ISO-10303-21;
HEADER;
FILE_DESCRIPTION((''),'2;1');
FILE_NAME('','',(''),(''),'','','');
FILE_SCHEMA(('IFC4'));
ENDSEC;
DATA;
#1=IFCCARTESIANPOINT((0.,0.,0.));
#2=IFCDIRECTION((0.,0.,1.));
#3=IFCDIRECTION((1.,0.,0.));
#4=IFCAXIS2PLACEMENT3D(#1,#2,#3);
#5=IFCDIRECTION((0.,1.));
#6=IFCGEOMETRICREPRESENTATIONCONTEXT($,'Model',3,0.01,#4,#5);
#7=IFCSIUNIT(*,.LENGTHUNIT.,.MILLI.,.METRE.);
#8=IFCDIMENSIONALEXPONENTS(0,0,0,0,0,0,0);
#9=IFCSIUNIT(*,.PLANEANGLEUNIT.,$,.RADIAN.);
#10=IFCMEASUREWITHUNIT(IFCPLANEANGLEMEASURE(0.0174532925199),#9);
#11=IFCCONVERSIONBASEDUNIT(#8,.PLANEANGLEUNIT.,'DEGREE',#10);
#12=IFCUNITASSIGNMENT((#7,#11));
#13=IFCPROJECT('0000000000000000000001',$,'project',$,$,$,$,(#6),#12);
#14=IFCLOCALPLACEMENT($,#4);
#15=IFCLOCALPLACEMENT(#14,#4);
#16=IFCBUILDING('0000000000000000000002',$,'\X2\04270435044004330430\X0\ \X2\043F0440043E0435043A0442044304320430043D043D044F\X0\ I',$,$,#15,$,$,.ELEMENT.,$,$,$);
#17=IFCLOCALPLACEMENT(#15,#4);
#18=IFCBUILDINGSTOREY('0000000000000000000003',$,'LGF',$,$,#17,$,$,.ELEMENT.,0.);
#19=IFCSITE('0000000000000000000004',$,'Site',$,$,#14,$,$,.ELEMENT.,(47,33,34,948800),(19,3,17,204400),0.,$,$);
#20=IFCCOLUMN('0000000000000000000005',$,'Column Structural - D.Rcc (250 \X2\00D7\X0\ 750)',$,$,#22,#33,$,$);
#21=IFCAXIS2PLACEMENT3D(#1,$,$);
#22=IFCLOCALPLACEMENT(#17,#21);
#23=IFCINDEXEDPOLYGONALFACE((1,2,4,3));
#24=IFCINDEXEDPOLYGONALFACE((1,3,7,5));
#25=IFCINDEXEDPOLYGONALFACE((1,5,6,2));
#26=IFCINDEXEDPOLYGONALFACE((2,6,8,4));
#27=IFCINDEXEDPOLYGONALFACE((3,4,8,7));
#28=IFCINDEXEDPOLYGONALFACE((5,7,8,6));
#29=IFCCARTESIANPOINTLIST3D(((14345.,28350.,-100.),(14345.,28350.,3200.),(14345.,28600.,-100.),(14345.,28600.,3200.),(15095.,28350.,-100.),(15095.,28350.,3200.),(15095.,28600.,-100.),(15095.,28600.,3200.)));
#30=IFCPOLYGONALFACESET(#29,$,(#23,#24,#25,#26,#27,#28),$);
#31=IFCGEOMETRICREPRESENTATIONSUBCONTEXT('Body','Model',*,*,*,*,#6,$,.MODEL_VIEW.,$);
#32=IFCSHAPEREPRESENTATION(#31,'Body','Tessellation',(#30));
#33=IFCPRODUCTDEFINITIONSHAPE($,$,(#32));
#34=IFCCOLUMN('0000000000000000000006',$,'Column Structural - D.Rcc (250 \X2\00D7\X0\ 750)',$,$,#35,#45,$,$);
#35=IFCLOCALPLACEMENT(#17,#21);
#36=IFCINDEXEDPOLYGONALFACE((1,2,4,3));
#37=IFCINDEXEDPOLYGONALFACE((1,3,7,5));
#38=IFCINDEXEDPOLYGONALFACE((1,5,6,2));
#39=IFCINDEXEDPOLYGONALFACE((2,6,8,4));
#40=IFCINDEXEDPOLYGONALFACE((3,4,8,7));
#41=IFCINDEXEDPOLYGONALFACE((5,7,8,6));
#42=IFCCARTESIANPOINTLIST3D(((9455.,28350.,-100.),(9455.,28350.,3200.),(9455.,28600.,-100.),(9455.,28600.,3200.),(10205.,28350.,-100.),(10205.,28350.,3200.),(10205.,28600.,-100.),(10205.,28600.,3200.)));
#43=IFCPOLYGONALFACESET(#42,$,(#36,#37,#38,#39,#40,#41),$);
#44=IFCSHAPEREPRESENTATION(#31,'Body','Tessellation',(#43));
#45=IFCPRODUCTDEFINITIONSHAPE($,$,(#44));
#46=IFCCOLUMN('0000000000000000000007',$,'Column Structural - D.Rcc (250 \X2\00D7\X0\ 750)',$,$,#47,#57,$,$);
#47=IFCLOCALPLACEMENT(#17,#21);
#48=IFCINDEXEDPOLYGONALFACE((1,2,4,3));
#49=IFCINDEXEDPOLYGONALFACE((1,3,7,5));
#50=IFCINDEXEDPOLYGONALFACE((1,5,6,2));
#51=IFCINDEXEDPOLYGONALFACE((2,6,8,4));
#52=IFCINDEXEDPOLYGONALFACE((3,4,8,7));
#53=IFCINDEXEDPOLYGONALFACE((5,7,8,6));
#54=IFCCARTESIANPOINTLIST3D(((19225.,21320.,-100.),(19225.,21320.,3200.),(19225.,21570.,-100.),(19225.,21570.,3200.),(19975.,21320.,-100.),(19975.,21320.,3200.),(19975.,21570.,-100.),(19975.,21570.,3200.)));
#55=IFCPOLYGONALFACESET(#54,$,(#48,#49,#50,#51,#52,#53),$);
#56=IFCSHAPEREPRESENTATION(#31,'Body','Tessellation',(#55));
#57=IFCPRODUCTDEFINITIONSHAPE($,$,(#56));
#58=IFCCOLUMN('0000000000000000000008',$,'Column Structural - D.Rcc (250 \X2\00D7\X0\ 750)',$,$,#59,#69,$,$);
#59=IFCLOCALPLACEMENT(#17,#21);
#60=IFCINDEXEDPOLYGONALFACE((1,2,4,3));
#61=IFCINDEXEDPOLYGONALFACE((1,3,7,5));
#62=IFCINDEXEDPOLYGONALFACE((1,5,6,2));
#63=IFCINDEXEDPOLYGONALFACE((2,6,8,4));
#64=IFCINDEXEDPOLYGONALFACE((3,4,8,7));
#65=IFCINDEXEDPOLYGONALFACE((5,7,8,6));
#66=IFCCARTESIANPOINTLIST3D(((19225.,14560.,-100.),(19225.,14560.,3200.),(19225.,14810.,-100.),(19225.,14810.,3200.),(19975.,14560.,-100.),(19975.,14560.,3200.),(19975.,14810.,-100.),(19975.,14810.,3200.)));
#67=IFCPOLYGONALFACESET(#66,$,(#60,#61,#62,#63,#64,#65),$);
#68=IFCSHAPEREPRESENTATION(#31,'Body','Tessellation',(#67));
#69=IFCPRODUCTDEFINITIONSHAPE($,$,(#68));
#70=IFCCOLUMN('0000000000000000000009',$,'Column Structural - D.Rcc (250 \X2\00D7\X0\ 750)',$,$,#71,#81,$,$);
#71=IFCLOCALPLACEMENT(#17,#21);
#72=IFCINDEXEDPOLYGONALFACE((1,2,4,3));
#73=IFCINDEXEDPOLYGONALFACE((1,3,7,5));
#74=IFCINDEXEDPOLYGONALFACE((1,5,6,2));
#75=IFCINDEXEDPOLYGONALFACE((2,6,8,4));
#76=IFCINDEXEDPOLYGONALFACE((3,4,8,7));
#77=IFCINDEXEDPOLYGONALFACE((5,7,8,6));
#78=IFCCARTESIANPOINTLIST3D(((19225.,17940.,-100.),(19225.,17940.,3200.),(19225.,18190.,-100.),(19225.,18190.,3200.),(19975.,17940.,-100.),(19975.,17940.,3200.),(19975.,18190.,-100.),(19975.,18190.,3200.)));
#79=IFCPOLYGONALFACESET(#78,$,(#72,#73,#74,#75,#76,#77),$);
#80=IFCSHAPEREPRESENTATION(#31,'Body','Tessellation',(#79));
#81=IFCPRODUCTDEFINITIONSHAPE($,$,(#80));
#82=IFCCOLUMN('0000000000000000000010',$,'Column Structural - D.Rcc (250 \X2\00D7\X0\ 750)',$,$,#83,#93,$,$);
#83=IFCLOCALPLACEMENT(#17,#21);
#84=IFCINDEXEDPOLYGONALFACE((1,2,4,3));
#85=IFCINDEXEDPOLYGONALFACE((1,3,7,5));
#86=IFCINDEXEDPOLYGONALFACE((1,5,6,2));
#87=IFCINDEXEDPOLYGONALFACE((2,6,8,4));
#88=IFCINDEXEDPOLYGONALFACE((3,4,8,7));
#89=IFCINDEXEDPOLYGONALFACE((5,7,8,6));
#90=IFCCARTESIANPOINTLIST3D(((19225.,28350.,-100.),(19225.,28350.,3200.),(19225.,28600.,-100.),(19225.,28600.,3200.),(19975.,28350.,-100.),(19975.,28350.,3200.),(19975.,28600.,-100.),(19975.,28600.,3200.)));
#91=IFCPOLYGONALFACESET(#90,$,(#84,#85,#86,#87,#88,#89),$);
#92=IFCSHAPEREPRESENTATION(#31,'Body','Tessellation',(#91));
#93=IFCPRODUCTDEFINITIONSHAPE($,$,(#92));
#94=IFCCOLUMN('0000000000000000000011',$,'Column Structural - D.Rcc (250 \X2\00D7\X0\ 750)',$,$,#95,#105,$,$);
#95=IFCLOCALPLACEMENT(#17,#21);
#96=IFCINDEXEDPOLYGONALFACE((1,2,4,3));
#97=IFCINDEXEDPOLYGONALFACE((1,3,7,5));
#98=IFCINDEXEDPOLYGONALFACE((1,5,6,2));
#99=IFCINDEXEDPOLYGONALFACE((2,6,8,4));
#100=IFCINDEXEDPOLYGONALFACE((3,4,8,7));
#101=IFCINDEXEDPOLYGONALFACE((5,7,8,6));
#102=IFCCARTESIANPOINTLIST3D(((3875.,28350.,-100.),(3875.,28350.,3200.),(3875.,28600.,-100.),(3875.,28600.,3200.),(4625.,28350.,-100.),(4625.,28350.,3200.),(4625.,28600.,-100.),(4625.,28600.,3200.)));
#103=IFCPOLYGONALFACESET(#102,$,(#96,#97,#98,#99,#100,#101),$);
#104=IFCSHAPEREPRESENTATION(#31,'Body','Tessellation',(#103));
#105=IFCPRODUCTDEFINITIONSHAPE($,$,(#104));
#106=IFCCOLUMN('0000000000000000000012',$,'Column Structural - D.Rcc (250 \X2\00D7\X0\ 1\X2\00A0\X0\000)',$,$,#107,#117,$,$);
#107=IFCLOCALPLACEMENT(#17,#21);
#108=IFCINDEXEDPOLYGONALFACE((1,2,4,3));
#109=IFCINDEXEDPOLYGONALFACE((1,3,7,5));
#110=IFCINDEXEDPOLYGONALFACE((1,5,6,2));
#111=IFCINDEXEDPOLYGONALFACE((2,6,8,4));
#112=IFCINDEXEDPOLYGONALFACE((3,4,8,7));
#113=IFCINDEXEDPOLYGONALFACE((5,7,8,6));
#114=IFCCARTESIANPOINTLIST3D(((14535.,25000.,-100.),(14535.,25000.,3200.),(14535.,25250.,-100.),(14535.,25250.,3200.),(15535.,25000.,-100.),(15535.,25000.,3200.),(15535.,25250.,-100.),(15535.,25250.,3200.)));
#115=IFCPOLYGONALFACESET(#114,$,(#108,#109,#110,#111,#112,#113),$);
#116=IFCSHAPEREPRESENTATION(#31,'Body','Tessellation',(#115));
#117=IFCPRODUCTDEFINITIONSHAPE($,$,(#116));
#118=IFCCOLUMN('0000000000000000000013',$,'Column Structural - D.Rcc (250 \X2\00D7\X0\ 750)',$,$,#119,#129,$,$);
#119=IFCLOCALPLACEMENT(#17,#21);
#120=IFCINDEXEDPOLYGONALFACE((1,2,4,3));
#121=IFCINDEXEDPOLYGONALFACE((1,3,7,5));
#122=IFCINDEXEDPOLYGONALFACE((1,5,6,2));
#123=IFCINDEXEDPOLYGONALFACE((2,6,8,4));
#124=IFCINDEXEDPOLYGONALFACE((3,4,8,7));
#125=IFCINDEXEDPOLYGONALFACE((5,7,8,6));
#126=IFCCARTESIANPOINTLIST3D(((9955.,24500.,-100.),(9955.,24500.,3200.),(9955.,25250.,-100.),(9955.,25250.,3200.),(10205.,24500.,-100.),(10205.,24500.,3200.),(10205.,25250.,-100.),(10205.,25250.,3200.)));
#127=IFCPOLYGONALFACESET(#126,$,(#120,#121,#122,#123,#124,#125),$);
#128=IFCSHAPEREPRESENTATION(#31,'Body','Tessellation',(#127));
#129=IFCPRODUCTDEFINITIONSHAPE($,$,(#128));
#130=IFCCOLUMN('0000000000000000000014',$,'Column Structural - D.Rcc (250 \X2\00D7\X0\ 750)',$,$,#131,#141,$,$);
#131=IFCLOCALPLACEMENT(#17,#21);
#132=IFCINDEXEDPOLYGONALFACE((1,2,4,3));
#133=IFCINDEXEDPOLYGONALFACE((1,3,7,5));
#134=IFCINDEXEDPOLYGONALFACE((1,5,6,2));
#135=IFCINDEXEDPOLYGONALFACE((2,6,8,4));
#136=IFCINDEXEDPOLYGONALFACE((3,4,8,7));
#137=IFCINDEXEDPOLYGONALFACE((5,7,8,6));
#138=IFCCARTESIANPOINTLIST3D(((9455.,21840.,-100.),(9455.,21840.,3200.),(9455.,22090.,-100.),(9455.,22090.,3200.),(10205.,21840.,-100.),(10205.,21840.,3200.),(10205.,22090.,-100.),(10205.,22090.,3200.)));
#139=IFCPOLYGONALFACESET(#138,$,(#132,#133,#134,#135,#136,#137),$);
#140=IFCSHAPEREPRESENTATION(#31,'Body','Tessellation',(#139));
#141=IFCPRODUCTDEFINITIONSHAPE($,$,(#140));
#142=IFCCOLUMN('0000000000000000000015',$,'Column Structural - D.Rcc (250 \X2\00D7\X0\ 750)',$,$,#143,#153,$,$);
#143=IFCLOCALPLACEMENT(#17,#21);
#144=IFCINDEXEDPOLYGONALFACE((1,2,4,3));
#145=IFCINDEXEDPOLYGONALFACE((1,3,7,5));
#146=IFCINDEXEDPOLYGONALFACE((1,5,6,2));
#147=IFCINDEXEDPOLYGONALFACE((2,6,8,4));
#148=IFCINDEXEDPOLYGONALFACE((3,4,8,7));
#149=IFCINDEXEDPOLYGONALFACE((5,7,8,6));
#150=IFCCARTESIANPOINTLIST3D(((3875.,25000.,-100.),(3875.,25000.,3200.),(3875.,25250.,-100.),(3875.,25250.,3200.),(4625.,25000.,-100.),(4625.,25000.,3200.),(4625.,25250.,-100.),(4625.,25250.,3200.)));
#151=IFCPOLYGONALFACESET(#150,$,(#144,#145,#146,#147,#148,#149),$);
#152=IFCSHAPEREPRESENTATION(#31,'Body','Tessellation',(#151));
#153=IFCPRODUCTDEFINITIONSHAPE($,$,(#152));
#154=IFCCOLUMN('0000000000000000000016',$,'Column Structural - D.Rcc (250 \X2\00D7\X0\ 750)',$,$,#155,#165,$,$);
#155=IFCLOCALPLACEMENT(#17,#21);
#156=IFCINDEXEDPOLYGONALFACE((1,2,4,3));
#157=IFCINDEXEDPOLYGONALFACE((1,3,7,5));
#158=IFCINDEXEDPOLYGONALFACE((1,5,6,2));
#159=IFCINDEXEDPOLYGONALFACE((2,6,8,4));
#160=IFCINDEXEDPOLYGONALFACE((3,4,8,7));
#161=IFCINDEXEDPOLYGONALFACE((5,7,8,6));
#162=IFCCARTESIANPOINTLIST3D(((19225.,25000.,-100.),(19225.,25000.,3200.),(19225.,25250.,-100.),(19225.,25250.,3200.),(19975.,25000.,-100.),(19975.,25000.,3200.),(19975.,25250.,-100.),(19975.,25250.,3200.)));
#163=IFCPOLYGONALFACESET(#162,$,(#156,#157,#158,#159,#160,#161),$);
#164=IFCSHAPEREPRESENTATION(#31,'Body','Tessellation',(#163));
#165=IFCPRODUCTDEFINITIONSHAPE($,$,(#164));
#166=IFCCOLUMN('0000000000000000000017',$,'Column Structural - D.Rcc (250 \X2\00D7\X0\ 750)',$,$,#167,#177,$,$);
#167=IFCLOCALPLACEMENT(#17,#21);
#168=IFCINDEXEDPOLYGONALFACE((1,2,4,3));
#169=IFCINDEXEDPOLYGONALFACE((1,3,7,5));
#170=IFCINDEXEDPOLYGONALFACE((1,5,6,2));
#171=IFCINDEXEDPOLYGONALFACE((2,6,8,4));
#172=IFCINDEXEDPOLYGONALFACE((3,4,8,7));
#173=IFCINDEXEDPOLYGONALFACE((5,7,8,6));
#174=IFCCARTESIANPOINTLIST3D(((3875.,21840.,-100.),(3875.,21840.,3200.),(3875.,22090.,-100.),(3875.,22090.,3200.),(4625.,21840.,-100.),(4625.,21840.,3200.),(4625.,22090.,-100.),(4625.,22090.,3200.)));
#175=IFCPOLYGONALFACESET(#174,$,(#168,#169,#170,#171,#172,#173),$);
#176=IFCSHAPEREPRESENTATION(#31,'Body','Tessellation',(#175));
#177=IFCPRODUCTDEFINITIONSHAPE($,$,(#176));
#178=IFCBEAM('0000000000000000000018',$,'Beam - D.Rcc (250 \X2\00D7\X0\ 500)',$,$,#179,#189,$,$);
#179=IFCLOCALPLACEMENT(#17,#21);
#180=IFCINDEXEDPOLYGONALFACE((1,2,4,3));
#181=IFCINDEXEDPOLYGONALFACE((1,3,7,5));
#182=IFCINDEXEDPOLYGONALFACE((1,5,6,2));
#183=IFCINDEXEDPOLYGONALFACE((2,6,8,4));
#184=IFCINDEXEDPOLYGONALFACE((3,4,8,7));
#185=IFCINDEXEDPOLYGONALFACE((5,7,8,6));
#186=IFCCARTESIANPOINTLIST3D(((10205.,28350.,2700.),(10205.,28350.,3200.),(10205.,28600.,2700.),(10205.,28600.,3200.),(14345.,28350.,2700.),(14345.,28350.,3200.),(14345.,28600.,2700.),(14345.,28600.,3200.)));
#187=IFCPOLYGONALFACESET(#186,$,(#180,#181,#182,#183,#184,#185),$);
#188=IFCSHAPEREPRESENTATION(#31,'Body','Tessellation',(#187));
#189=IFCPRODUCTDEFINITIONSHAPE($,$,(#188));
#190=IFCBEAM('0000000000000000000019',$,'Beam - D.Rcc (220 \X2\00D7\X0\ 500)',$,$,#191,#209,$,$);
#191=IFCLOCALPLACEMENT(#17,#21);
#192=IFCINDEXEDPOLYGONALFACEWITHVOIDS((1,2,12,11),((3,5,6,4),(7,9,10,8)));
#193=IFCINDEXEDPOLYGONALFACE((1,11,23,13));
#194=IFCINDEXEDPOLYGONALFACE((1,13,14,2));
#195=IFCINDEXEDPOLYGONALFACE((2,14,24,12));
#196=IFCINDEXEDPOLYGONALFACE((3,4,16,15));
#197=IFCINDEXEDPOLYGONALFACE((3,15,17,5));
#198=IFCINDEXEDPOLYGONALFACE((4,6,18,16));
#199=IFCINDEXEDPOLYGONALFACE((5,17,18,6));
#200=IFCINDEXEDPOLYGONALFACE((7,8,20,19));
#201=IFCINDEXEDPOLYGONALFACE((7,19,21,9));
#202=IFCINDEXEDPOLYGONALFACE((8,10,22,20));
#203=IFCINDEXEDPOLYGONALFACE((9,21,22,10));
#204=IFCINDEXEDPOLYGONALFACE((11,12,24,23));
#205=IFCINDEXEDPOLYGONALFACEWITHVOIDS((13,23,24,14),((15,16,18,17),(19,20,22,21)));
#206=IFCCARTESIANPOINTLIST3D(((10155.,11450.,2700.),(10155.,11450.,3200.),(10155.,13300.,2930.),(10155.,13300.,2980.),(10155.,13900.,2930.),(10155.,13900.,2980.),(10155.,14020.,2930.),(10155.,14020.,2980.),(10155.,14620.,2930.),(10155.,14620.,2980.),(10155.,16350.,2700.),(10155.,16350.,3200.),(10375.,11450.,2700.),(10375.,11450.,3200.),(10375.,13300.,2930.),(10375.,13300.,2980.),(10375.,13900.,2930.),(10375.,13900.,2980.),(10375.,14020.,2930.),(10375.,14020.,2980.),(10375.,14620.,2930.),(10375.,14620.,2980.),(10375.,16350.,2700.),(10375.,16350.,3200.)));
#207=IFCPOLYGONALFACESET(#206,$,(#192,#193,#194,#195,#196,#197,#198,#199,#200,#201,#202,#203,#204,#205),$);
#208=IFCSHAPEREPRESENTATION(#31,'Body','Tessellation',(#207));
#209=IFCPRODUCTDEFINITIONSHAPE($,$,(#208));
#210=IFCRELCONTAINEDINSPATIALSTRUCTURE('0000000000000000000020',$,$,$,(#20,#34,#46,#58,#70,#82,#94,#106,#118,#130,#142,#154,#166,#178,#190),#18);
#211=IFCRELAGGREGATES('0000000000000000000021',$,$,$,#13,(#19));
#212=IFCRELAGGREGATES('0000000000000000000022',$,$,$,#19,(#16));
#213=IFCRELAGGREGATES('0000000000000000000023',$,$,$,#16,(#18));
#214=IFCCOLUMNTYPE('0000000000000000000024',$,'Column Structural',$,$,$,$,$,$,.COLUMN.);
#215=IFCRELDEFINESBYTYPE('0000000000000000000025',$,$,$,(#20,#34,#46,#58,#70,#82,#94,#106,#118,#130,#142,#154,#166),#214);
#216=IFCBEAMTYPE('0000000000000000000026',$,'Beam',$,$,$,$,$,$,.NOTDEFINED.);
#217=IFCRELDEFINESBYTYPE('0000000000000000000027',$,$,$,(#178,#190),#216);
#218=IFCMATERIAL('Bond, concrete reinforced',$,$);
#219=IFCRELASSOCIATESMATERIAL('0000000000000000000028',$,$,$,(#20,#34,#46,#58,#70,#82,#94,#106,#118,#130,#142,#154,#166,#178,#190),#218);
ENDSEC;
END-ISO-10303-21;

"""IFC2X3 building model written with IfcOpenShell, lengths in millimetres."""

from ifc_helpers import new_model, entity, si_unit, converted_unit, direction, frame, frame_2d, origin_with_axes, origin_2d_with_axis, place, context, subcontext, project, spatial, rectangle, extrude, material, type_object, element, save


model = new_model("IFC2X3")

# Units and contexts
model_context = context("Model", 3, precision=0.01, world=origin_with_axes(), true_north=direction((0.0, 1.0)))
body_context = subcontext(model_context, "Body", "Model", "MODEL_VIEW")
ifc_project = project(units=[si_unit("LENGTHUNIT", "METRE", prefix="MILLI"), converted_unit("PLANEANGLEUNIT", "DEGREE", entity("IfcPlaneAngleMeasure", 0.0174532925199), si_unit("PLANEANGLEUNIT", "RADIAN"), dimensions=[0, 0, 0, 0, 0, 0, 0])], contexts=[model_context])

# Site, building, storey
site_placement = place(None, origin_with_axes())
site = spatial("IfcSite", under=ifc_project, at=site_placement, Name="Site", CompositionType="ELEMENT", RefLatitude=(47, 33, 34, 948800), RefLongitude=(19, 3, 17, 204400), RefElevation=0.0)
building_placement = place(site_placement, origin_with_axes())
building = spatial("IfcBuilding", under=site, at=building_placement, Name="Черга проектування I", CompositionType="ELEMENT")
storey_placement = place(building_placement, origin_with_axes())
storey = spatial("IfcBuildingStorey", under=building, at=storey_placement, Name="LGF", CompositionType="ELEMENT", Elevation=0.0)

# Columns
ifc_material = material(Name="Bond, concrete reinforced")
column_type = type_object("IfcColumnType", Name="Column Structural", PredefinedType="COLUMN")
for number, where, z_axis, x_axis, name in (
    (1, (14720.0, 28475.0, -100.0), (0.0, 0.0, 1.0), (-1.0, 0.0, 0.0), "Column Structural - D.Rcc (250 × 750)"),
    (2, (9830.0, 28475.0, -100.0), (0.0, 0.0, 1.0), (-1.0, 0.0, 0.0), "Column Structural - D.Rcc (250 × 750)"),
    (3, (19600.0, 21445.0, -100.0), (0.0, 0.0, 1.0), (-1.0, 0.0, 0.0), "Column Structural - D.Rcc (250 × 750)"),
    (4, (19600.0, 14685.0, -100.0), (0.0, 0.0, 1.0), (-1.0, 0.0, 0.0), "Column Structural - D.Rcc (250 × 750)"),
    (5, (19600.0, 18065.0, -100.0), (0.0, 0.0, 1.0), (-1.0, 0.0, 0.0), "Column Structural - D.Rcc (250 × 750)"),
    (6, (19600.0, 28475.0, -100.0), (0.0, 0.0, 1.0), (-1.0, 0.0, 0.0), "Column Structural - D.Rcc (250 × 750)"),
    (7, (4250.0, 28475.0, -100.0), (0.0, 0.0, 1.0), (-1.0, 0.0, 0.0), "Column Structural - D.Rcc (250 × 750)"),
):
    element("IfcColumn", number, at=place(storey_placement, frame(where, z_axis=z_axis, x_axis=x_axis)), inside=storey, type_object=column_type, material=ifc_material, Name=name, context=body_context, shape_type="SweptSolid", body=[
        extrude(rectangle(XDim=750.0, YDim=250.0, at=origin_2d_with_axis()), origin_with_axes(), (0.0, 0.0, 1.0), 3300.0),
    ])
column_placement = place(storey_placement, frame((15035.0, 25125.0, -100.0), z_axis=(0.0, 0.0, 1.0), x_axis=(-1.0, 0.0, 0.0)))
element("IfcColumn", 8, at=column_placement, inside=storey, type_object=column_type, material=ifc_material, Name="Column Structural - D.Rcc (250 × 1 000)", context=body_context, shape_type="SweptSolid", body=[
    extrude(rectangle(XDim=1000.0, YDim=250.0, at=origin_2d_with_axis()), origin_with_axes(), (0.0, 0.0, 1.0), 3300.0),
])
for number, where, z_axis, x_axis, name in (
    (9, (10080.0, 24875.0, -100.0), (0.0, 0.0, 1.0), (0.0, -1.0, 0.0), "Column Structural - D.Rcc (250 × 750)"),
    (10, (9830.0, 21965.0, -100.0), (0.0, 0.0, 1.0), (-1.0, 0.0, 0.0), "Column Structural - D.Rcc (250 × 750)"),
    (11, (4250.0, 25125.0, -100.0), (0.0, 0.0, 1.0), (1.0, 0.0, 0.0), "Column Structural - D.Rcc (250 × 750)"),
    (12, (19600.0, 25125.0, -100.0), (0.0, 0.0, 1.0), (-1.0, 0.0, 0.0), "Column Structural - D.Rcc (250 × 750)"),
    (13, (4250.0, 21965.0, -100.0), (0.0, 0.0, 1.0), (-1.0, 0.0, 0.0), "Column Structural - D.Rcc (250 × 750)"),
):
    element("IfcColumn", number, at=place(storey_placement, frame(where, z_axis=z_axis, x_axis=x_axis)), inside=storey, type_object=column_type, material=ifc_material, Name=name, context=body_context, shape_type="SweptSolid", body=[
        extrude(rectangle(XDim=750.0, YDim=250.0, at=origin_2d_with_axis()), origin_with_axes(), (0.0, 0.0, 1.0), 3300.0),
    ])

# Beam
beam_type = type_object("IfcBeamType", Name="Beam", PredefinedType="NOTDEFINED")
beam_1_placement = place(storey_placement, frame((10205.0, 28475.0, 2700.0), z_axis=(0.0, 0.0, 1.0), x_axis=(0.0, -1.0, 0.0)))
element("IfcBeam", 14, at=beam_1_placement, inside=storey, type_object=beam_type, material=ifc_material, Name="Beam - D.Rcc (250 × 500)", context=body_context, shape_type="SweptSolid", body=[
    extrude(rectangle(XDim=500.0, YDim=250.0, at=frame_2d((250.0, 0.0), x_axis=(1.0, 0.0))), frame((0.0, 0.0, 0.0), z_axis=(0.0, 1.0, 0.0), x_axis=(0.0, 0.0, 1.0)), (0.0, 0.0, 1.0), 4140.0),
])

# Beam, openings
beam_2_placement = place(storey_placement, frame((10265.0, 16350.0, 2700.0), z_axis=(0.0, 0.0, 1.0), x_axis=(-1.0, 0.0, 0.0)))
beam_2 = element("IfcBeam", 15, at=beam_2_placement, inside=storey, type_object=beam_type, material=ifc_material, Name="Beam - D.Rcc (220 × 500)", context=body_context, shape_type="SweptSolid", body=[
    extrude(rectangle(XDim=500.0, YDim=220.0, at=frame_2d((250.0, 0.0), x_axis=(1.0, 0.0))), frame((0.0, 0.0, 0.0), z_axis=(0.0, 1.0, 0.0), x_axis=(0.0, 0.0, 1.0)), (0.0, 0.0, 1.0), 4900.0),
])
opening_1_placement = place(beam_2_placement, frame((10265.0, 16350.0, -2700.0), z_axis=(0.0, 0.0, 1.0), x_axis=(-1.0, 0.0, 0.0)))
element("IfcOpeningElement", 16, at=opening_1_placement, cuts=beam_2, ObjectType="OPENING", context=body_context, shape_type="SweptSolid", body=[
    extrude(rectangle(XDim=600.0, YDim=50.0, at=origin_2d_with_axis()), frame((9935.0, 14320.0, 2955.0), z_axis=(-1.0, 0.0, 0.0), x_axis=(0.0, -1.0, 0.0)), (0.0, 0.0, -1.0), 660.0),
])
opening_2_placement = place(beam_2_placement, frame((10265.0, 16350.0, -2700.0), z_axis=(0.0, 0.0, 1.0), x_axis=(-1.0, 0.0, 0.0)))
element("IfcOpeningElement", 17, at=opening_2_placement, cuts=beam_2, ObjectType="OPENING", context=body_context, shape_type="SweptSolid", body=[
    extrude(rectangle(XDim=600.0, YDim=50.0, at=origin_2d_with_axis()), frame((9935.0, 13600.0, 2955.0), z_axis=(-1.0, 0.0, 0.0), x_axis=(0.0, -1.0, 0.0)), (0.0, 0.0, -1.0), 660.0),
])

save(model, "model.ifc")
